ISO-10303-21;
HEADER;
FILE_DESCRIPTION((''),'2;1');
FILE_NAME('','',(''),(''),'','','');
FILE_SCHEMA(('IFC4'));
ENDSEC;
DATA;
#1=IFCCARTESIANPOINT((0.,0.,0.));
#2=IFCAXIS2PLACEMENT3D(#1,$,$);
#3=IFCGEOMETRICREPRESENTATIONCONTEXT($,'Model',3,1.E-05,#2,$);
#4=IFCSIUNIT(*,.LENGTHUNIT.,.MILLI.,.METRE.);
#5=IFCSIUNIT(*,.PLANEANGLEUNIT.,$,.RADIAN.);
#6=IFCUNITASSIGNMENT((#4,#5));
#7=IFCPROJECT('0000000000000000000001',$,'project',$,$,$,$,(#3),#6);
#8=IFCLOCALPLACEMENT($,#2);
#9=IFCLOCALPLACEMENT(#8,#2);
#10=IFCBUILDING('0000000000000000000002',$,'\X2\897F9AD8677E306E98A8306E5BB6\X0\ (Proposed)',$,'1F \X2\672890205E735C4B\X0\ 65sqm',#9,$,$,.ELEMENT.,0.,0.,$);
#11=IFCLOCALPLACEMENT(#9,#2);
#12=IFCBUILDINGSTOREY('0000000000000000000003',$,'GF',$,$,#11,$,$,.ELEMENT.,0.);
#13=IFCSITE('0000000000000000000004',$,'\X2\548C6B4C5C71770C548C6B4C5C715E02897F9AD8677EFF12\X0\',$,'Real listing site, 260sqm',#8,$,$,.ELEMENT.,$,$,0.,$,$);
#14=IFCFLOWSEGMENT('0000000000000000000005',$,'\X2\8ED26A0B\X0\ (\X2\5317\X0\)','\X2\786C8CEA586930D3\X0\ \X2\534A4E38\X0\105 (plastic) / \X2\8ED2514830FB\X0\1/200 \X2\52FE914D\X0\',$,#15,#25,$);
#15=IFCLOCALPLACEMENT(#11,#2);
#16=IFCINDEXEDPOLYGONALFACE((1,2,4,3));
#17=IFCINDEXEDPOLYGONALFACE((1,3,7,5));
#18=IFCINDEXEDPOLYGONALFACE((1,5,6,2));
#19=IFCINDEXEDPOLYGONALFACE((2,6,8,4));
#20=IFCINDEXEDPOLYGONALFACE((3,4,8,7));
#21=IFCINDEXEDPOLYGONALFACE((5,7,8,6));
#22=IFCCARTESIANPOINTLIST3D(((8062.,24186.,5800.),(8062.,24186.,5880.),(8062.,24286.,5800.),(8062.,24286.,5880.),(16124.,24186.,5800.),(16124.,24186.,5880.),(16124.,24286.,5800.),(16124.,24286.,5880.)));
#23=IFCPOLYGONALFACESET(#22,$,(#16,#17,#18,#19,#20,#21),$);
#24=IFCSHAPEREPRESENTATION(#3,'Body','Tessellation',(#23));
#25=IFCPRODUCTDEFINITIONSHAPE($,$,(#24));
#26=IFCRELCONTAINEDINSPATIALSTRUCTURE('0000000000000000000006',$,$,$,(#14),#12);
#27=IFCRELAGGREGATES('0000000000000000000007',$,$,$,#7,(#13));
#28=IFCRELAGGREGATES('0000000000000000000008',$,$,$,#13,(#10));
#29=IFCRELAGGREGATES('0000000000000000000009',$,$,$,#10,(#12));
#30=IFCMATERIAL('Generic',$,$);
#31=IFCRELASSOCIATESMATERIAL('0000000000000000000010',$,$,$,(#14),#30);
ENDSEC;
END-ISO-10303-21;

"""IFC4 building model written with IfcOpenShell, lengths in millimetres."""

from ifc_helpers import new_model, si_unit, frame, frame_2d, origin, place, context, project, spatial, rectangle, extrude, material, element, save


model = new_model("IFC4")

# Units and contexts
model_context = context("Model", 3, precision=1e-05, world=origin())
ifc_project = project(units=[si_unit("LENGTHUNIT", "METRE", prefix="MILLI"), si_unit("PLANEANGLEUNIT", "RADIAN")], contexts=[model_context])

# Site, building, storey
site_placement = place(None, origin())
site = spatial("IfcSite", under=ifc_project, at=site_placement, Name="和歌山県和歌山市西高松２", ObjectType="Real listing site, 260sqm", CompositionType="ELEMENT", RefElevation=0.0)
building_placement = place(site_placement, origin())
building = spatial("IfcBuilding", under=site, at=building_placement, Name="西高松の風の家 (Proposed)", ObjectType="1F 木造平屋 65sqm", CompositionType="ELEMENT", ElevationOfRefHeight=0.0, ElevationOfTerrain=0.0)
storey_placement = place(building_placement, origin())
storey = spatial("IfcBuildingStorey", under=building, at=storey_placement, Name="GF", CompositionType="ELEMENT", Elevation=0.0)

# Shared definitions
ifc_material_1 = material(Name="Generic")

# Flow segment
flow_segment_1_placement = place(storey_placement, frame((4031.0, 12093.0, 2900.0)))
element("IfcFlowSegment", 1, at=flow_segment_1_placement, inside=storey, material=ifc_material_1, Name="軒樋 (北)", Description="硬質塩ビ 半丸105 (plastic) / 軒先・1/200 勾配", context=model_context, shape_type="SweptSolid", body=[
    extrude(rectangle(XDim=8062.0, YDim=100.0, at=frame_2d((4031.0, 50.0))), frame((4031.0, 12093.0, 2900.0)), (0.0, 0.0, 1.0), 80.0),
])

save(model, "model.ifc")
